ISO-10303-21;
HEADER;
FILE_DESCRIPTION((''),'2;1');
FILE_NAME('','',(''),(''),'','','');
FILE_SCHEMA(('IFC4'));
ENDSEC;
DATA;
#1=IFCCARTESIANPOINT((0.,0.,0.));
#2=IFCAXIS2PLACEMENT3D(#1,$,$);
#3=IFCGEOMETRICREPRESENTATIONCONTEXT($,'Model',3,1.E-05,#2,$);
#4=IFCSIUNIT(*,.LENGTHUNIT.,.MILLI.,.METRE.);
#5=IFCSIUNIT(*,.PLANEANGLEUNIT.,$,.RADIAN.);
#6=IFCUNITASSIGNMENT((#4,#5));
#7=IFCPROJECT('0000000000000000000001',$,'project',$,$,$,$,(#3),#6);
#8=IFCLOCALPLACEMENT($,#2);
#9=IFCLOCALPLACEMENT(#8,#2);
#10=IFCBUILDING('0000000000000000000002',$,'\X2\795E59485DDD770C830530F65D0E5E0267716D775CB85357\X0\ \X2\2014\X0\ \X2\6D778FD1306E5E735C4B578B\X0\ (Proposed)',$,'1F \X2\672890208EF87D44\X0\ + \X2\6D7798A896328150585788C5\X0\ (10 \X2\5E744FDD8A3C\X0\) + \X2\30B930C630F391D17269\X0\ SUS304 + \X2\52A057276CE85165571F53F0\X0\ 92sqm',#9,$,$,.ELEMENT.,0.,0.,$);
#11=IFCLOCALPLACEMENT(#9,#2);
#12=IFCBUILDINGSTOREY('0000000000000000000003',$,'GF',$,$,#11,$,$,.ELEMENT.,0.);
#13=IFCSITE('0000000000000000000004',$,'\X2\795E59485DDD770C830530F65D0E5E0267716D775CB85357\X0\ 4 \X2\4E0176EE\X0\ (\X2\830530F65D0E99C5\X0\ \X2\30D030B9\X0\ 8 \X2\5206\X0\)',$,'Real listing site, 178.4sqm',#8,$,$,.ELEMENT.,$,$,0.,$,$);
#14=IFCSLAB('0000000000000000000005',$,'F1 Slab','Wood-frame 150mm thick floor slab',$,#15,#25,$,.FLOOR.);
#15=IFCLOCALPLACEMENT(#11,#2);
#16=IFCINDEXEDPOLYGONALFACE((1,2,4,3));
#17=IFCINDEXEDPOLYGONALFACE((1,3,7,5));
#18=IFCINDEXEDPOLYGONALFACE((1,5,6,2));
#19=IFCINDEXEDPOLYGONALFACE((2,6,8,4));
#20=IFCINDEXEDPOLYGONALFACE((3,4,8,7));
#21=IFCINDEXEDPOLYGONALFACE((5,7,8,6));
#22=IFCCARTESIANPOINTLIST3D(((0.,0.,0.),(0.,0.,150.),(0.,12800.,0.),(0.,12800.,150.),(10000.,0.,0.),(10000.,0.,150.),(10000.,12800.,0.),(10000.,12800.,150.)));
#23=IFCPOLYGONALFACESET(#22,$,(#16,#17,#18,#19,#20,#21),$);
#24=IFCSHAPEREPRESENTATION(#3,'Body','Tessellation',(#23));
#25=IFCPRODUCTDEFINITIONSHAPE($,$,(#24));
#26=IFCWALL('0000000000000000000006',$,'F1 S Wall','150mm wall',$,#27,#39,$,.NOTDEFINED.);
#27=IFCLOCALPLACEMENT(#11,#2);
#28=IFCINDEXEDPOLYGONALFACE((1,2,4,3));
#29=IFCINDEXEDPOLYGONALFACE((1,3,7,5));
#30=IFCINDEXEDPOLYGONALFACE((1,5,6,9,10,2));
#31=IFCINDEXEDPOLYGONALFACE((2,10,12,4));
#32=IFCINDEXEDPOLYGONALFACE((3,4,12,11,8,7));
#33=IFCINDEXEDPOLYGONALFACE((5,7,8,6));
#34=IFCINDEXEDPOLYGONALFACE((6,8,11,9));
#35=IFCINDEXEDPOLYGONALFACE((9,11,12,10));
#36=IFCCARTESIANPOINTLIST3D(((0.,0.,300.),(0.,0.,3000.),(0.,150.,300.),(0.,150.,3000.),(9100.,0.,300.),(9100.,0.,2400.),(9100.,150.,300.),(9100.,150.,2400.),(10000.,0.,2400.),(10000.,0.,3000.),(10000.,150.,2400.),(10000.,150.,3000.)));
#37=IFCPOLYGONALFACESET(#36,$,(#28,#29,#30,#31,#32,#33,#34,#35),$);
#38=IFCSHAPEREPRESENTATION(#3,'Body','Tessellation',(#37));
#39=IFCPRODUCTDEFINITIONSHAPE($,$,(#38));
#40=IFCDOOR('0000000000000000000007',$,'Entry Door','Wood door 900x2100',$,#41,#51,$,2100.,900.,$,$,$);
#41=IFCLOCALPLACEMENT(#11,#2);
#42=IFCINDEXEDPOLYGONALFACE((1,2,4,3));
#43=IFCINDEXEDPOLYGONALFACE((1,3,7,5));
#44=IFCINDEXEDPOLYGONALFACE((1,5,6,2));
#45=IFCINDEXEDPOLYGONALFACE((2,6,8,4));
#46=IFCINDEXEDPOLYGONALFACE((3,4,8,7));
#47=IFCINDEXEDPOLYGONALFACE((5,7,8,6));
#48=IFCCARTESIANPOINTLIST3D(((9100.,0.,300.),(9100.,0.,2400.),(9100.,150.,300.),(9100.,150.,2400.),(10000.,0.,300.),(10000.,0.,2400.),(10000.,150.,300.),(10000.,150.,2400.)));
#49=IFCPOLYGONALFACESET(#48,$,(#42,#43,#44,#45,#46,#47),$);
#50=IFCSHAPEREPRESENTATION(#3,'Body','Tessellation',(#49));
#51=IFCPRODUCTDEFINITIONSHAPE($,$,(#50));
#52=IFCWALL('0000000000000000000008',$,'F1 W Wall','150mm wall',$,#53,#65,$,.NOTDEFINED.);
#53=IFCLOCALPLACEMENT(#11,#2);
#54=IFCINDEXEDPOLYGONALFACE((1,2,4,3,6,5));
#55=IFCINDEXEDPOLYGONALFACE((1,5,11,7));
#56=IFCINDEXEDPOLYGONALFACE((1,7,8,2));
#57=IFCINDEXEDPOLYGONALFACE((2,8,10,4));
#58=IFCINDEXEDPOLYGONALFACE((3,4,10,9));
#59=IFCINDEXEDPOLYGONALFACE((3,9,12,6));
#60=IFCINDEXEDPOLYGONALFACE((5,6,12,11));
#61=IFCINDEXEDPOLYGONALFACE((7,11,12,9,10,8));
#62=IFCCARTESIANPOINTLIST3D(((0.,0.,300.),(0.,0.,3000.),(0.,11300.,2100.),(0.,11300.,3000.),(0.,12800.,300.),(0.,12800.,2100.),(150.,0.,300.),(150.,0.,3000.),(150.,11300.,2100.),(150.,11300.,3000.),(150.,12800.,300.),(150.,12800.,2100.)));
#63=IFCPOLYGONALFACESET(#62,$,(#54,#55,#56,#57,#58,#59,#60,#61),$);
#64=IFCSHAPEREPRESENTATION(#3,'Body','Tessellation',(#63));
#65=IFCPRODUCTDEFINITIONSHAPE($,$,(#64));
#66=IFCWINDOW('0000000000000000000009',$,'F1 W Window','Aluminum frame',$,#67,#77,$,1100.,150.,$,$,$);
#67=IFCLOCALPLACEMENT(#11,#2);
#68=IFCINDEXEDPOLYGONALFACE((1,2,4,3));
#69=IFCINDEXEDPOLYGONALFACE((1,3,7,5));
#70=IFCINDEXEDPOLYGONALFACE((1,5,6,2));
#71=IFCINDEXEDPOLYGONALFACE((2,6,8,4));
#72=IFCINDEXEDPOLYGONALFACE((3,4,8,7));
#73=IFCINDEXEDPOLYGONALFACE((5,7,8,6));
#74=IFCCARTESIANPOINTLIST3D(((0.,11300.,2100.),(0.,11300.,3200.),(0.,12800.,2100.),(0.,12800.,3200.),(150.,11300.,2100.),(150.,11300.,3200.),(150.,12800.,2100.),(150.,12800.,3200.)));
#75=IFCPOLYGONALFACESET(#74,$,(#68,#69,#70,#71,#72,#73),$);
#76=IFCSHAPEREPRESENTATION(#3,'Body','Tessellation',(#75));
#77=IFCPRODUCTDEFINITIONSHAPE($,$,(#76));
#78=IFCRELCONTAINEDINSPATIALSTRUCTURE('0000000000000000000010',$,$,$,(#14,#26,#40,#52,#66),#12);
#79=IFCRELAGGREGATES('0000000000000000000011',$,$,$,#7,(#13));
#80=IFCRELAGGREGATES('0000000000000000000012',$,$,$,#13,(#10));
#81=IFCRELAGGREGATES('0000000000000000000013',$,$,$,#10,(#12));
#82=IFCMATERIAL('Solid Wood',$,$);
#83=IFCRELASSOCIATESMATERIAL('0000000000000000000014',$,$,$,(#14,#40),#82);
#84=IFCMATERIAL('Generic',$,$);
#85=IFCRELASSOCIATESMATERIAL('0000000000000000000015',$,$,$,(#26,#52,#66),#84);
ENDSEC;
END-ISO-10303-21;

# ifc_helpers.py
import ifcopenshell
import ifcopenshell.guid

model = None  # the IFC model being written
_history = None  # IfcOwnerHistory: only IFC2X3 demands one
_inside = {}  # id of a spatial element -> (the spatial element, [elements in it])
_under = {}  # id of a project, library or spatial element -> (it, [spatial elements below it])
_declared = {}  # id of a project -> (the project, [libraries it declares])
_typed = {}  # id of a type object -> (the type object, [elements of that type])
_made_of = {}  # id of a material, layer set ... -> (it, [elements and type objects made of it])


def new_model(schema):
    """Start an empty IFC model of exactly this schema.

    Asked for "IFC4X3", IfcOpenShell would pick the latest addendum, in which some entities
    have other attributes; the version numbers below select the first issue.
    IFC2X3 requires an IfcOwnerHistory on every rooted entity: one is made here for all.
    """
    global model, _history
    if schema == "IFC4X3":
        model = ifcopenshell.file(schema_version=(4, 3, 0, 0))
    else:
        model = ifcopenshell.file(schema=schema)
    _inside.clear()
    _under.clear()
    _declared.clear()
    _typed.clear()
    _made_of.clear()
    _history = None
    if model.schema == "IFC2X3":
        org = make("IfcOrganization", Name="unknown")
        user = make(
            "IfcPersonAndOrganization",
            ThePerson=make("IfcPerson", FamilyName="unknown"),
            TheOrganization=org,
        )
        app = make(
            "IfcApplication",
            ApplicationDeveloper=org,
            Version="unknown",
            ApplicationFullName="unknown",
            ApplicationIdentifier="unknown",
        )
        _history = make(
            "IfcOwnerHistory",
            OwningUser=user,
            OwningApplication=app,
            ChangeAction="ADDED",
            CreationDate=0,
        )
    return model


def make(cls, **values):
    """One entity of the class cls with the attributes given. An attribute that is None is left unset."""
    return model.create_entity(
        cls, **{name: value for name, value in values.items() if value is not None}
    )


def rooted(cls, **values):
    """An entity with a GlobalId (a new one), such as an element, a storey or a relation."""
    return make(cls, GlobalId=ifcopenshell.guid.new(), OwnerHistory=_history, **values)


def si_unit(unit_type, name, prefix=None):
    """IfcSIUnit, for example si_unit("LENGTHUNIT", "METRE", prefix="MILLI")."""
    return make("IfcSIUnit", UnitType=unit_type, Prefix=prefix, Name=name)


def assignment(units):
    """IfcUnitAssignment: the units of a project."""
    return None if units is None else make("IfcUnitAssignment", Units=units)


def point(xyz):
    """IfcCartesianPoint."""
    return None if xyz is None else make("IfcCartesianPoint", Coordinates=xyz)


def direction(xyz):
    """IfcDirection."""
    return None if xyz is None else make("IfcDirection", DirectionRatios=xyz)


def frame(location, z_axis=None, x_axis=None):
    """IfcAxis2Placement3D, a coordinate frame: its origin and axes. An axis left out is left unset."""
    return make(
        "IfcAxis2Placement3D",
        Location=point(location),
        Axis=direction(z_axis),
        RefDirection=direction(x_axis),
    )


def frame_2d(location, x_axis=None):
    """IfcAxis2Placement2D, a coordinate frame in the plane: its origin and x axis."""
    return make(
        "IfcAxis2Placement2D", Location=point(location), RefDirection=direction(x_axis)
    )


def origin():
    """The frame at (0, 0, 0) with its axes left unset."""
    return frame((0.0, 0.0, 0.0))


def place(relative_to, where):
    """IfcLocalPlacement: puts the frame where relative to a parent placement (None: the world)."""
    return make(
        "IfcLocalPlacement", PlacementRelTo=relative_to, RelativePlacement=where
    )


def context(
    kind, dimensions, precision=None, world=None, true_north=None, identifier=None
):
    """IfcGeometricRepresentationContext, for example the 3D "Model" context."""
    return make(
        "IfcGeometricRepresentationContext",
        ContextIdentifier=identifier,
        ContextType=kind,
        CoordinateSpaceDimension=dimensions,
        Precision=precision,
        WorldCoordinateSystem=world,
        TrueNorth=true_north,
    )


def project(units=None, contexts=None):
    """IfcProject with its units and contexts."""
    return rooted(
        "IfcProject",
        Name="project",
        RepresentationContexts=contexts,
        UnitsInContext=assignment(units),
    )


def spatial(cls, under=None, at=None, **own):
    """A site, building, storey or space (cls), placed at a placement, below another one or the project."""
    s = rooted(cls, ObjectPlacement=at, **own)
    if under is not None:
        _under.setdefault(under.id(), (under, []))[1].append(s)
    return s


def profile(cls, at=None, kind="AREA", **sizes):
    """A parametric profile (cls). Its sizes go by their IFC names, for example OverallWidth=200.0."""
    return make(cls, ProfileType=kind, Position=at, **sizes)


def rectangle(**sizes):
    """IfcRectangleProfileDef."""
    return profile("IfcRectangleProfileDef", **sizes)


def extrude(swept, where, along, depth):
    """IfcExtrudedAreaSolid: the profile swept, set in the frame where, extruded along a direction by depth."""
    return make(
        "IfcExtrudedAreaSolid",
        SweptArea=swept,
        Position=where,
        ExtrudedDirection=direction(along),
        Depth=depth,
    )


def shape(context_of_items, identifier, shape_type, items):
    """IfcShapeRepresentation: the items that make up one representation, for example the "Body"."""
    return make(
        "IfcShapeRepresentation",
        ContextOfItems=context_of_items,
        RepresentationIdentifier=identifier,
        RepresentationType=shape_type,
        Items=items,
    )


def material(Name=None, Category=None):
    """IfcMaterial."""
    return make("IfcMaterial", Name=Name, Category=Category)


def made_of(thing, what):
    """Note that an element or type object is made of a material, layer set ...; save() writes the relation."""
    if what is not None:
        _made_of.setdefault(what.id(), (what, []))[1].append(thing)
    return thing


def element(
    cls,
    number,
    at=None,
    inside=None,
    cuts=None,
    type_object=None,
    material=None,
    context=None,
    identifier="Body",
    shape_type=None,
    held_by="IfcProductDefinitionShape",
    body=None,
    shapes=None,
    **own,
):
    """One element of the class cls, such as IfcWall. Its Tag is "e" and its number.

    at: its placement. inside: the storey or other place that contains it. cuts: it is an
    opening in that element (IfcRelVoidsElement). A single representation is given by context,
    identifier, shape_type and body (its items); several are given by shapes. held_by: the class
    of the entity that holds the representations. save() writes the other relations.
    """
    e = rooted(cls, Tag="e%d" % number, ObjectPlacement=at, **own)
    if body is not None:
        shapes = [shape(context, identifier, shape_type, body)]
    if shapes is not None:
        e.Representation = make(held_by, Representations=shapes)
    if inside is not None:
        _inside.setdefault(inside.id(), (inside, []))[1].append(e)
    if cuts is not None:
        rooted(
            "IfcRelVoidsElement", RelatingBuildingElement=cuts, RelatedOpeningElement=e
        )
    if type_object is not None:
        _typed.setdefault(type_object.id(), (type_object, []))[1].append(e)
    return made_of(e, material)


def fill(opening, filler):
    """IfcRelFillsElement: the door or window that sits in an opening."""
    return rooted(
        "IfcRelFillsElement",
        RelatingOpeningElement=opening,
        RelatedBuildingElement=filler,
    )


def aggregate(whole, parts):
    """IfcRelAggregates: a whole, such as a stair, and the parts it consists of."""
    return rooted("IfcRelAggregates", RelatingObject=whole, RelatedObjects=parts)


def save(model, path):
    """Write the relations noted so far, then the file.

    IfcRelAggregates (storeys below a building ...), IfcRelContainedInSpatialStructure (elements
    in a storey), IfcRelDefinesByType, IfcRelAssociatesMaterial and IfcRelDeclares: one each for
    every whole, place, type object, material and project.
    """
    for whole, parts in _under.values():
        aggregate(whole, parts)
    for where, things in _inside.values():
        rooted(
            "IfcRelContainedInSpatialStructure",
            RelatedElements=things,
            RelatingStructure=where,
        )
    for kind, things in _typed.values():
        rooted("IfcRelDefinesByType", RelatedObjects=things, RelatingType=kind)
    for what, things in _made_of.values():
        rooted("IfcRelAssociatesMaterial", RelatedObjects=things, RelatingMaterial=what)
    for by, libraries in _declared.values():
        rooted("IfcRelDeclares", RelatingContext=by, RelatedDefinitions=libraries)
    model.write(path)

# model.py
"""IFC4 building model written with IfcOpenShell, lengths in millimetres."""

from ifc_helpers import new_model, si_unit, frame, frame_2d, origin, place, context, project, spatial, rectangle, extrude, material, element, fill, save


model = new_model("IFC4")

# Units and contexts
model_context = context("Model", 3, precision=1e-05, world=origin())
ifc_project = project(units=[si_unit("LENGTHUNIT", "METRE", prefix="MILLI"), si_unit("PLANEANGLEUNIT", "RADIAN")], contexts=[model_context])

# Site, building, storey
site_placement = place(None, origin())
site = spatial("IfcSite", under=ifc_project, at=site_placement, Name="神奈川県茅ヶ崎市東海岸南 4 丁目 (茅ヶ崎駅 バス 8 分)", ObjectType="Real listing site, 178.4sqm", CompositionType="ELEMENT", RefElevation=0.0)
building_placement = place(site_placement, origin())
building = spatial("IfcBuilding", under=site, at=building_placement, Name="神奈川県茅ヶ崎市東海岸南 — 海近の平屋型 (Proposed)", ObjectType="1F 木造軸組 + 海風防腐塗装 (10 年保証) + ステン金物 SUS304 + 加圧注入土台 92sqm", CompositionType="ELEMENT", ElevationOfRefHeight=0.0, ElevationOfTerrain=0.0)
storey_placement = place(building_placement, origin())
storey = spatial("IfcBuildingStorey", under=building, at=storey_placement, Name="GF", CompositionType="ELEMENT", Elevation=0.0)

# Slab
ifc_material_1 = material(Name="Solid Wood")
slab_placement = place(storey_placement, origin())
element("IfcSlab", 1, at=slab_placement, inside=storey, material=ifc_material_1, Name="F1 Slab", Description="Wood-frame 150mm thick floor slab", PredefinedType="FLOOR", context=model_context, shape_type="SweptSolid", body=[
    extrude(rectangle(XDim=10000.0, YDim=12800.0, at=frame_2d((5000.0, 6400.0))), origin(), (0.0, 0.0, 1.0), 150.0),
])

# Shared definitions
ifc_material_2 = material(Name="Generic")

# Wall, opening, door
wall_1_placement = place(storey_placement, frame((0.0, 0.0, 150.0)))
wall_1 = element("IfcWall", 2, at=wall_1_placement, inside=storey, material=ifc_material_2, Name="F1 S Wall", Description="150mm wall", PredefinedType="NOTDEFINED", context=model_context, shape_type="SweptSolid", body=[
    extrude(rectangle(XDim=10000.0, YDim=150.0, at=frame_2d((5000.0, 75.0))), frame((0.0, 0.0, 150.0)), (0.0, 0.0, 1.0), 2700.0),
])
opening_1_placement = place(storey_placement, frame((4550.0, 0.0, 150.0)))
opening_1 = element("IfcOpeningElement", 3, at=opening_1_placement, cuts=wall_1, PredefinedType="NOTDEFINED", context=model_context, shape_type="SweptSolid", body=[
    extrude(rectangle(XDim=900.0, YDim=150.0, at=frame_2d((450.0, 75.0))), frame((4550.0, 0.0, 150.0)), (0.0, 0.0, 1.0), 2100.0),
])
door_placement = place(storey_placement, frame((4550.0, 0.0, 150.0)))
door = element("IfcDoor", 4, at=door_placement, inside=storey, material=ifc_material_1, Name="Entry Door", Description="Wood door 900x2100", OverallHeight=2100.0, OverallWidth=900.0, context=model_context, shape_type="SweptSolid", body=[
    extrude(rectangle(XDim=900.0, YDim=150.0, at=frame_2d((450.0, 75.0))), frame((4550.0, 0.0, 150.0)), (0.0, 0.0, 1.0), 2100.0),
])
fill(opening_1, door)

# Wall, opening, window
wall_2_placement = place(storey_placement, frame((0.0, 0.0, 150.0)))
wall_2 = element("IfcWall", 5, at=wall_2_placement, inside=storey, material=ifc_material_2, Name="F1 W Wall", Description="150mm wall", PredefinedType="NOTDEFINED", context=model_context, shape_type="SweptSolid", body=[
    extrude(rectangle(XDim=150.0, YDim=12800.0, at=frame_2d((75.0, 6400.0))), frame((0.0, 0.0, 150.0)), (0.0, 0.0, 1.0), 2700.0),
])
opening_2_placement = place(storey_placement, frame((0.0, 5650.0, 1050.0)))
opening_2 = element("IfcOpeningElement", 6, at=opening_2_placement, cuts=wall_2, PredefinedType="NOTDEFINED", context=model_context, shape_type="SweptSolid", body=[
    extrude(rectangle(XDim=150.0, YDim=1500.0, at=frame_2d((75.0, 750.0))), frame((0.0, 5650.0, 1050.0)), (0.0, 0.0, 1.0), 1100.0),
])
window_1_placement = place(storey_placement, frame((0.0, 5650.0, 1050.0)))
window_1 = element("IfcWindow", 7, at=window_1_placement, inside=storey, material=ifc_material_2, Name="F1 W Window", Description="Aluminum frame", OverallHeight=1100.0, OverallWidth=150.0, context=model_context, shape_type="SweptSolid", body=[
    extrude(rectangle(XDim=150.0, YDim=1500.0, at=frame_2d((75.0, 750.0))), frame((0.0, 5650.0, 1050.0)), (0.0, 0.0, 1.0), 1100.0),
])
fill(opening_2, window_1)

save(model, "model.ifc")
